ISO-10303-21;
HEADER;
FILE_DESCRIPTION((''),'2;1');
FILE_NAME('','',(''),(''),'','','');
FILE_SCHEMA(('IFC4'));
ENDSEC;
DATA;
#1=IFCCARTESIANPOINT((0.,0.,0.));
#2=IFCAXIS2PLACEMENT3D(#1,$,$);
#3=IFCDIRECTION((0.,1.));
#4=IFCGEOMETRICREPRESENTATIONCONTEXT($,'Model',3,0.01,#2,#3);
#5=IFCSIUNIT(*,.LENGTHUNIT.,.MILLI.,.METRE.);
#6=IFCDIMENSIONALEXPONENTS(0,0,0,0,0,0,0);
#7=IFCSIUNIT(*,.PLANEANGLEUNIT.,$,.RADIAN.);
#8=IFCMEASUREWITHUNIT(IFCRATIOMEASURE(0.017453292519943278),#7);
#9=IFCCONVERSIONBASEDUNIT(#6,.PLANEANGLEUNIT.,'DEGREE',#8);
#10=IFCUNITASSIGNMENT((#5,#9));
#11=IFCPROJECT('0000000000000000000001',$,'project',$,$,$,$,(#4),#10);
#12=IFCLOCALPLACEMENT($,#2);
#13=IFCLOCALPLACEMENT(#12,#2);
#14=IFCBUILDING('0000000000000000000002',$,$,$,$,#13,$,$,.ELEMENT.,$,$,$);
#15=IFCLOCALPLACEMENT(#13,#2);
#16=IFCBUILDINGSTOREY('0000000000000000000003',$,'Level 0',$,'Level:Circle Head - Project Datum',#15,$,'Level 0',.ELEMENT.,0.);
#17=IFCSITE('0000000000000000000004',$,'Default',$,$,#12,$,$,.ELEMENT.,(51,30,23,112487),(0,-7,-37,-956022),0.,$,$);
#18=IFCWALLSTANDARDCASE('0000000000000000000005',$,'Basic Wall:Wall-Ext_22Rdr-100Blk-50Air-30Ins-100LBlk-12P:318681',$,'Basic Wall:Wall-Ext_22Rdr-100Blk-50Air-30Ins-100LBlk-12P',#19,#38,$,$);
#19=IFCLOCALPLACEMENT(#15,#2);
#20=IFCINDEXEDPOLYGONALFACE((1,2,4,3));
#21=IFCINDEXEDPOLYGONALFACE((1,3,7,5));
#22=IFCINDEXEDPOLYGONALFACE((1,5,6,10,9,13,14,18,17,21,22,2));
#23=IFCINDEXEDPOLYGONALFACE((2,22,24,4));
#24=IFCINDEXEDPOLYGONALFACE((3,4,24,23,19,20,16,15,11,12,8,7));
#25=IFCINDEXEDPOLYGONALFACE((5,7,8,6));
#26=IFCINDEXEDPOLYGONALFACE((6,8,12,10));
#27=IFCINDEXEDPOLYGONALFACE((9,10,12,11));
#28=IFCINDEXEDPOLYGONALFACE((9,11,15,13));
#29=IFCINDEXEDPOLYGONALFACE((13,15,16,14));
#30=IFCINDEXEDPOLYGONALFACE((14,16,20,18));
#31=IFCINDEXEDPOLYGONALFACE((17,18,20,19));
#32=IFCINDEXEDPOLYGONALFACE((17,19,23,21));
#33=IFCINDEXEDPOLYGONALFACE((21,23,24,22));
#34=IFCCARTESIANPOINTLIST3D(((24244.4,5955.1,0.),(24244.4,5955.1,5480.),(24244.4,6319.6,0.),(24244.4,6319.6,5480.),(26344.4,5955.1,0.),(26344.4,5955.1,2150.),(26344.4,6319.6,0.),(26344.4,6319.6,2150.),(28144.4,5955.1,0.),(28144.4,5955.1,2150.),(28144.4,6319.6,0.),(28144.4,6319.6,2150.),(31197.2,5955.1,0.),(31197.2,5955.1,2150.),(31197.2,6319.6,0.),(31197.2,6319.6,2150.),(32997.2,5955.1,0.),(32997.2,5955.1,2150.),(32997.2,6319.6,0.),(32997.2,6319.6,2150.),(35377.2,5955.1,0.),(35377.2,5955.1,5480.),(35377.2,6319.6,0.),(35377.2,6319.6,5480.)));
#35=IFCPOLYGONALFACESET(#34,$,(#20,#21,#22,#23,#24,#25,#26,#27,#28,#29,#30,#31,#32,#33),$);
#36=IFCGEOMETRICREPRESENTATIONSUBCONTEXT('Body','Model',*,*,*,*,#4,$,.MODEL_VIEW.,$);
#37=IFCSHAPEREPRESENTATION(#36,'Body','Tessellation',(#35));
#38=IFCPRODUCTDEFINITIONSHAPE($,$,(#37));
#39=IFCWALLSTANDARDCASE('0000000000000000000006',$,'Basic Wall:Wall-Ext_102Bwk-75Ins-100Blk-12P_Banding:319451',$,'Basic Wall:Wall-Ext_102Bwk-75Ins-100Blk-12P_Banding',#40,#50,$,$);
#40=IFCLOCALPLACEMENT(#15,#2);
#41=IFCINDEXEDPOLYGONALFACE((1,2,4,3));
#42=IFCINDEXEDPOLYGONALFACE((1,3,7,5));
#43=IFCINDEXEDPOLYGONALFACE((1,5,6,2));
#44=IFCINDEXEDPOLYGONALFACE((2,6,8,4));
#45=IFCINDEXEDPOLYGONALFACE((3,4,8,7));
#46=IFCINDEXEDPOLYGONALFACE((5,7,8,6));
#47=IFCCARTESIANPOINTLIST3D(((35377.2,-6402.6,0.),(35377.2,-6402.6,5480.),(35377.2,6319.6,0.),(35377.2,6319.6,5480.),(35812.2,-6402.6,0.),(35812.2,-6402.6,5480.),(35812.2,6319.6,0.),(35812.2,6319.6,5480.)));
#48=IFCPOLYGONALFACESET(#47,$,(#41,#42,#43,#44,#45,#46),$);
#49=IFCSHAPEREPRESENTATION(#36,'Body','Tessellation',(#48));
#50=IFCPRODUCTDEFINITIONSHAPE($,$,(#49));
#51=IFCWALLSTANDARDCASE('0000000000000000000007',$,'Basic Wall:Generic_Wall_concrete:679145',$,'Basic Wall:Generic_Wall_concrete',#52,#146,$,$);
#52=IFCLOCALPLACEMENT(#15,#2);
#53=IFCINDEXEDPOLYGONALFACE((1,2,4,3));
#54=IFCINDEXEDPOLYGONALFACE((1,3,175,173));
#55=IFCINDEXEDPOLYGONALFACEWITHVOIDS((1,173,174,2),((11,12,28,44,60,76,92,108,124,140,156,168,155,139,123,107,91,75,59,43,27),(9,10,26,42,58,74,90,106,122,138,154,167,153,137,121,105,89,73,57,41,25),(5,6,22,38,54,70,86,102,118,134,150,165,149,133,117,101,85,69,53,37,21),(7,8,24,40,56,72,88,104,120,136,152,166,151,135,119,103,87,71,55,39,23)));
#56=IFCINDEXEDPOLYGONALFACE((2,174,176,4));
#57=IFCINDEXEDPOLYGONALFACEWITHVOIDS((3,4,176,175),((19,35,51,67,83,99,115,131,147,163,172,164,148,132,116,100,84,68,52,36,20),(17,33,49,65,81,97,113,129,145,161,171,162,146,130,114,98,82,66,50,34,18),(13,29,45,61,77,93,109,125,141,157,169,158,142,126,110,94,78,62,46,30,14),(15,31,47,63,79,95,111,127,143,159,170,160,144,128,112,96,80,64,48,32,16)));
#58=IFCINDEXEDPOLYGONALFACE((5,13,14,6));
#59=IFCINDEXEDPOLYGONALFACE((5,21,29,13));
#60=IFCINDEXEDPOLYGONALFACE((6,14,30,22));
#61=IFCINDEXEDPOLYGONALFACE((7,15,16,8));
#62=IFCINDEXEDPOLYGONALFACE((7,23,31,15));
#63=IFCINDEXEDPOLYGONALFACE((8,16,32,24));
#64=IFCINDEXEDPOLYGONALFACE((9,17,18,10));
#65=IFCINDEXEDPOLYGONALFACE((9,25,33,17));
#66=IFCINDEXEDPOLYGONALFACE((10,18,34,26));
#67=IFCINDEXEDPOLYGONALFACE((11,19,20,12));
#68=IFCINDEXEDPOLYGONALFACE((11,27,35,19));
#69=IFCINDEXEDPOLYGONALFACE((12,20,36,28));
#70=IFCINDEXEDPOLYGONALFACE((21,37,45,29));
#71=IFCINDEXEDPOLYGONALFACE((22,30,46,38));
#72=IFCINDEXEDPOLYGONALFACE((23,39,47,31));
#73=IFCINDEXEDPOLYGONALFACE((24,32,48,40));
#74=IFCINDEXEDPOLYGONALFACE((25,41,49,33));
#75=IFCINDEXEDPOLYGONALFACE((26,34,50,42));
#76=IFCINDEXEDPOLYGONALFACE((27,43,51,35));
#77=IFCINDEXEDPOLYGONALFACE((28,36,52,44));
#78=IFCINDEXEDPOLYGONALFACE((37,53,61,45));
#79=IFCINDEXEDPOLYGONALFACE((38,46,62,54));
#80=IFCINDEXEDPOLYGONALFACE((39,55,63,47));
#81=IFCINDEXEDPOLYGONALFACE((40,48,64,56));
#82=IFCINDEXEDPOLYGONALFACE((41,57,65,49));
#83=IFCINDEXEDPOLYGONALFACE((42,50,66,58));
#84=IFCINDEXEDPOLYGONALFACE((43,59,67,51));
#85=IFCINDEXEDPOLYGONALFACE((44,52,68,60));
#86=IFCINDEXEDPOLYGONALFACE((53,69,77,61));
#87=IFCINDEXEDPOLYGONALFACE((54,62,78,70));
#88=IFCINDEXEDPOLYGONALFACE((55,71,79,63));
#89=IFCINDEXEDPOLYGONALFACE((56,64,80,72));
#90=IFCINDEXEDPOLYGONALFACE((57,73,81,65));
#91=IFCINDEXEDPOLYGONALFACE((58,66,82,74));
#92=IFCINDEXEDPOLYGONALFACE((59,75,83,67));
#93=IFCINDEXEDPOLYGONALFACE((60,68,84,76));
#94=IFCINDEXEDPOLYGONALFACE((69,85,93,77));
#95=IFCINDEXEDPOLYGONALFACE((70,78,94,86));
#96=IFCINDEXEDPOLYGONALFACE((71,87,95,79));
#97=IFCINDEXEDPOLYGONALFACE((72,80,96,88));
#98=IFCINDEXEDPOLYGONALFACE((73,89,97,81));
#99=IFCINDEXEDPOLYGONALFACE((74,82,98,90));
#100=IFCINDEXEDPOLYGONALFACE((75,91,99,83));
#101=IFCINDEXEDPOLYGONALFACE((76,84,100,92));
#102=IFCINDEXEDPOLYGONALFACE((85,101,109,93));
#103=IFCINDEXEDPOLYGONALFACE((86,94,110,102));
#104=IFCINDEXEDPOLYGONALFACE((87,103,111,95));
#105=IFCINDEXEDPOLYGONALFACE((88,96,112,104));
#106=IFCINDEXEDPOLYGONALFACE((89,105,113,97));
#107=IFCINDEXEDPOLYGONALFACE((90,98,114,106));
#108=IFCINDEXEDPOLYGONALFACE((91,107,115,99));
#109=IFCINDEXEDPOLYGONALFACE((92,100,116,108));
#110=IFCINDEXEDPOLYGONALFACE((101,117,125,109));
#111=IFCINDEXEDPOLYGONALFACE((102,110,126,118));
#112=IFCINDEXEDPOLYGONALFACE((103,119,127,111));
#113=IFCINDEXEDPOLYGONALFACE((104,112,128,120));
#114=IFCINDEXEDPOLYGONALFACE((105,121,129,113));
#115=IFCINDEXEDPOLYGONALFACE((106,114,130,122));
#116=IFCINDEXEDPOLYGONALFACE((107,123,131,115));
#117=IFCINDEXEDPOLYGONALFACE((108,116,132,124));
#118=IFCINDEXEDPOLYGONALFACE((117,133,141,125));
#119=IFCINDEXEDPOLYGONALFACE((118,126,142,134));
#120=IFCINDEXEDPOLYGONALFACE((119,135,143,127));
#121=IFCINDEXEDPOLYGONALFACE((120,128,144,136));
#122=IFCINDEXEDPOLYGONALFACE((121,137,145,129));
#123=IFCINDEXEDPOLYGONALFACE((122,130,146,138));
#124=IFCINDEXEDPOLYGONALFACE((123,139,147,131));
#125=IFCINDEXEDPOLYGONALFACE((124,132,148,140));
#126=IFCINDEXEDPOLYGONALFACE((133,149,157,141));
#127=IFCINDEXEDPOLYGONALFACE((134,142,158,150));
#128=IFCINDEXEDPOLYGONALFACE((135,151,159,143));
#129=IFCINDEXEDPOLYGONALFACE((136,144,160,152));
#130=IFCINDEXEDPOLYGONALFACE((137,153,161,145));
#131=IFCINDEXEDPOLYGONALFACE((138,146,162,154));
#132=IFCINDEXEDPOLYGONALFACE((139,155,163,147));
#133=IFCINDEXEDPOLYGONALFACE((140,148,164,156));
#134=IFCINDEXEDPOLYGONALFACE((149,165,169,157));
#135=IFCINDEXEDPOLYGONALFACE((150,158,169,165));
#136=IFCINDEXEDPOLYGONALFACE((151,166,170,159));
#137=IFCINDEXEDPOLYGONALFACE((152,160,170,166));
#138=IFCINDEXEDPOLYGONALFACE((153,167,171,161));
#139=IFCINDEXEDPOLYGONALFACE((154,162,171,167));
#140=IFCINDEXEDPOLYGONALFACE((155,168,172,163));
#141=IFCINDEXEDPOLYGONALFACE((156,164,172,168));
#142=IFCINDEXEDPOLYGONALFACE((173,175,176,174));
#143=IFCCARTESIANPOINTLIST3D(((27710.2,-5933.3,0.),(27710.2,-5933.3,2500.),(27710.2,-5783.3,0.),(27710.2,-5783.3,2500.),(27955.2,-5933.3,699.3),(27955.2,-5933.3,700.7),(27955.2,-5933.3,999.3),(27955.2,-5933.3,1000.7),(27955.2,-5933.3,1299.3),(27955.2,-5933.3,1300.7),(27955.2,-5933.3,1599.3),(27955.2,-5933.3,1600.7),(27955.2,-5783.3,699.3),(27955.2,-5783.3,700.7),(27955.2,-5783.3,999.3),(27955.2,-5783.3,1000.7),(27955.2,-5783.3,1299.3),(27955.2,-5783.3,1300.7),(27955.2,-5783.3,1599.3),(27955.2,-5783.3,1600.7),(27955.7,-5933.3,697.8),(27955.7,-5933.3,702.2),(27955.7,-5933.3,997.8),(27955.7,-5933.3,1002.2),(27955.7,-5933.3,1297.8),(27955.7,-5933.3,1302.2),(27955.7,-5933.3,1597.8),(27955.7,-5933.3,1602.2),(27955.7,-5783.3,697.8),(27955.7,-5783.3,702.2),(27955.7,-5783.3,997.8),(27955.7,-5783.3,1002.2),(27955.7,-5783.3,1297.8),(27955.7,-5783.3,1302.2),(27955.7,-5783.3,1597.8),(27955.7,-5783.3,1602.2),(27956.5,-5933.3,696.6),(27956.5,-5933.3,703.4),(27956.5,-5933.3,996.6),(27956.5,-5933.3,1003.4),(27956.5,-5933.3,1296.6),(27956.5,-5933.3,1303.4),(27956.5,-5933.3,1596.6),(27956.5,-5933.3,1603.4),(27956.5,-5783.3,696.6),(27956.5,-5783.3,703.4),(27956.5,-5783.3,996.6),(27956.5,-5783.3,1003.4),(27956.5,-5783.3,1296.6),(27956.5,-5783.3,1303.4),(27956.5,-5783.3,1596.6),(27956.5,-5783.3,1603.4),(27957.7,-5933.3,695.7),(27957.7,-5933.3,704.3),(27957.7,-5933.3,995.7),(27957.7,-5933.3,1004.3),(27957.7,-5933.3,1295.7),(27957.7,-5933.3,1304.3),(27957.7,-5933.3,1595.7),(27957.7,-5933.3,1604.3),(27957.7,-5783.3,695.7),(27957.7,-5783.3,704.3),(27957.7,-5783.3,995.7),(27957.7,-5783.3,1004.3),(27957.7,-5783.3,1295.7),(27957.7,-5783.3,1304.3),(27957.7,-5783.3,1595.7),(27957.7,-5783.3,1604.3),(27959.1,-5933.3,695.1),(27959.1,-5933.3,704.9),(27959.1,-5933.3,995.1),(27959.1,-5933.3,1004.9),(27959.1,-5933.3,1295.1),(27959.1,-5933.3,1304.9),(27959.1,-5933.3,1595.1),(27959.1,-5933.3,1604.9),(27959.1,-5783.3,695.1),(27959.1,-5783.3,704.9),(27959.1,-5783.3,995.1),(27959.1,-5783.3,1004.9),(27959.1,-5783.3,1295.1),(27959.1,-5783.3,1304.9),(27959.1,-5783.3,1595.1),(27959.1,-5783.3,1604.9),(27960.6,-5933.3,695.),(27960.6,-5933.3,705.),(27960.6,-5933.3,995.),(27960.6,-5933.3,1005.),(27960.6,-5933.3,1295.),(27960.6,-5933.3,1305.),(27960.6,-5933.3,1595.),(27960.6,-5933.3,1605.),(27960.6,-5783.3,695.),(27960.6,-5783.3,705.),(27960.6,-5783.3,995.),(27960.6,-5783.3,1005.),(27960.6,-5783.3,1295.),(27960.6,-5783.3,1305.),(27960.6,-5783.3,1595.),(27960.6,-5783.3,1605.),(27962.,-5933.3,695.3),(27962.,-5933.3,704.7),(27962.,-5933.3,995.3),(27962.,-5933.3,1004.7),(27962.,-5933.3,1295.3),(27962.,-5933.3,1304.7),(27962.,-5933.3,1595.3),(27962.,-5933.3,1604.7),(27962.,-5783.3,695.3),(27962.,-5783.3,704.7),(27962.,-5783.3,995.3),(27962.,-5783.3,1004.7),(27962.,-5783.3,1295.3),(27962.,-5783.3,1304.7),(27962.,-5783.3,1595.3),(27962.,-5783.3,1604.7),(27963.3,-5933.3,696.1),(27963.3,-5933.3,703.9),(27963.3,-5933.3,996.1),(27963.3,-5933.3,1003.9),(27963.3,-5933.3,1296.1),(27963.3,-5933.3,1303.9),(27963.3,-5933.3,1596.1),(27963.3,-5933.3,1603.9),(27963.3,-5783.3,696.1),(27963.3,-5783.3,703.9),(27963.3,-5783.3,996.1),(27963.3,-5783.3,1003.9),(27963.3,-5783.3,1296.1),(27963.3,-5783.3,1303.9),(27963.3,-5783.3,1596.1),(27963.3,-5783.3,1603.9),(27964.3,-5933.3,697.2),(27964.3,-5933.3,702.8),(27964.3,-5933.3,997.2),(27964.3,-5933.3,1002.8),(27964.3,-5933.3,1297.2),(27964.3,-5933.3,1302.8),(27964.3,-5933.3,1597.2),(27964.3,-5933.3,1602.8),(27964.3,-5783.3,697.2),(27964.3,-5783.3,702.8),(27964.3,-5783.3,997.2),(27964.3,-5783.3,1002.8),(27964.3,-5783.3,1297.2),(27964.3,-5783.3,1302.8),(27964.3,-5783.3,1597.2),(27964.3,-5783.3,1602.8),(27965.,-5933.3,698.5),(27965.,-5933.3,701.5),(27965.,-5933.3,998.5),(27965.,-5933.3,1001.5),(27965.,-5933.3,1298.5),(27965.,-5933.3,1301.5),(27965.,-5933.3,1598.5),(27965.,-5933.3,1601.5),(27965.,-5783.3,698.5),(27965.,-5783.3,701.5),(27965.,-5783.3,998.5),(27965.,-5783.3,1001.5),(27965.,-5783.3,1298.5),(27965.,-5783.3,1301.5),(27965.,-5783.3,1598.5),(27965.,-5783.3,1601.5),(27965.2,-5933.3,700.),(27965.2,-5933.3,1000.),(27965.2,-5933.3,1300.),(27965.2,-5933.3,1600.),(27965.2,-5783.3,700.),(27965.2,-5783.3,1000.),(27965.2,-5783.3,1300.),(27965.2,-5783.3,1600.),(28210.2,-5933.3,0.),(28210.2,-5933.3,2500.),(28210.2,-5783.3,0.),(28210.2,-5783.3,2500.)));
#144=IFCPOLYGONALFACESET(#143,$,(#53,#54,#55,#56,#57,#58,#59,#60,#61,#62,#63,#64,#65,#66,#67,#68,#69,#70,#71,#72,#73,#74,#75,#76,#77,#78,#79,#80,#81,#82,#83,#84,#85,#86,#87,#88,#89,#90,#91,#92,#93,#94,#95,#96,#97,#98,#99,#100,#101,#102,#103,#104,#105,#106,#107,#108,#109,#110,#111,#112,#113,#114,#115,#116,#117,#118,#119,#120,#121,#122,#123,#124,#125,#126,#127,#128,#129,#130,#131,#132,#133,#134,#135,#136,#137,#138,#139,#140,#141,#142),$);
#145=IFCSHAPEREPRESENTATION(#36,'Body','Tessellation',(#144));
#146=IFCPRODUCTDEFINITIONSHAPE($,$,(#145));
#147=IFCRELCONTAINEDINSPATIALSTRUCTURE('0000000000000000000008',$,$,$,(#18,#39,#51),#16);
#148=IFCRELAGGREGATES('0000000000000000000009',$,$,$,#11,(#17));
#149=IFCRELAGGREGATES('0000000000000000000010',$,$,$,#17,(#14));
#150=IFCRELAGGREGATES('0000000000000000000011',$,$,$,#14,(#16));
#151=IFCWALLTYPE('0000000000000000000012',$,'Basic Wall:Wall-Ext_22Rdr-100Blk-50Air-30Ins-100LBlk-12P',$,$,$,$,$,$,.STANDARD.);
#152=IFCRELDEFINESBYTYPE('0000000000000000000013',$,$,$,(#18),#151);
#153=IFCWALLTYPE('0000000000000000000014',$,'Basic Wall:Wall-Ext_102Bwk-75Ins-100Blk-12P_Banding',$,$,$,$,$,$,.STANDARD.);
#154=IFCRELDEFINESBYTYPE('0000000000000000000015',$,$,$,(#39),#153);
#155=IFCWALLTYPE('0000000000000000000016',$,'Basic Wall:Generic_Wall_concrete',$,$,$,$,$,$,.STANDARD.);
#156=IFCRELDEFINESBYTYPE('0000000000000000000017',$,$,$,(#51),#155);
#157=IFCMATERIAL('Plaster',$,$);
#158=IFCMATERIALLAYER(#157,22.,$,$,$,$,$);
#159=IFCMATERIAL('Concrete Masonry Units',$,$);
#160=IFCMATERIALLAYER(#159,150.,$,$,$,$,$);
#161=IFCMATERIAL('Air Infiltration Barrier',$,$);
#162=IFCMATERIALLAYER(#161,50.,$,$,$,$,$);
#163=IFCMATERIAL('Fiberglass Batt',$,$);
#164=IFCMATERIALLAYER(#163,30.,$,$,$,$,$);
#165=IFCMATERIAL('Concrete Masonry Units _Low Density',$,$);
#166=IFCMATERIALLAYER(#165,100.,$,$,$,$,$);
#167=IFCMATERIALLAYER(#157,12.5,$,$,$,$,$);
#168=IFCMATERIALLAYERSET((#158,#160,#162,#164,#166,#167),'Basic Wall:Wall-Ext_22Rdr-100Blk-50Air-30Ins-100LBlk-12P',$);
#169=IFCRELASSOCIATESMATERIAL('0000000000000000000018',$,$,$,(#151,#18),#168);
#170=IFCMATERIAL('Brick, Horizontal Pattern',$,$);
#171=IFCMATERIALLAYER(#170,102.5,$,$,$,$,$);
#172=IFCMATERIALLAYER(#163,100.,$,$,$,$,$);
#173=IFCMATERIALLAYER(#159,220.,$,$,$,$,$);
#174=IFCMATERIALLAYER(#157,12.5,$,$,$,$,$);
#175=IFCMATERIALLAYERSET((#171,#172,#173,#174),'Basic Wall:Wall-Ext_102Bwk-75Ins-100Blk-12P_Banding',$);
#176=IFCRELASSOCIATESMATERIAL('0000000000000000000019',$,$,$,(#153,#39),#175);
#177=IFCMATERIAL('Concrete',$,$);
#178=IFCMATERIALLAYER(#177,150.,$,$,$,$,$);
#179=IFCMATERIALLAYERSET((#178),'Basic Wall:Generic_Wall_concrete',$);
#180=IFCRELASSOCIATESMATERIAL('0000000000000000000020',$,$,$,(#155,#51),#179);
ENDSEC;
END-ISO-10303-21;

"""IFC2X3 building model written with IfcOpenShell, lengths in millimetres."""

from ifc_helpers import new_model, entity, si_unit, converted_unit, direction, frame, frame_2d, origin, origin_2d_with_axis, place, context, subcontext, project, spatial, rectangle, circle, extrude, material, layer, layer_set, layer_usage, type_object, element, save


model = new_model("IFC2X3")

# Units and contexts
model_context = context("Model", 3, precision=0.01, world=origin(), true_north=direction((0.0, 1.0)))
body_context = subcontext(model_context, "Body", "Model", "MODEL_VIEW")
ifc_project = project(units=[si_unit("LENGTHUNIT", "METRE", prefix="MILLI"), converted_unit("PLANEANGLEUNIT", "DEGREE", entity("IfcRatioMeasure", 0.017453292519943278), si_unit("PLANEANGLEUNIT", "RADIAN"), dimensions=[0, 0, 0, 0, 0, 0, 0])], contexts=[model_context])

# Site, building, storey
site_placement = place(None, origin())
site = spatial("IfcSite", under=ifc_project, at=site_placement, Name="Default", CompositionType="ELEMENT", RefLatitude=(51, 30, 23, 112487), RefLongitude=(0, -7, -37, -956022), RefElevation=0.0)
building_placement = place(site_placement, origin())
building = spatial("IfcBuilding", under=site, at=building_placement, CompositionType="ELEMENT")
storey_placement = place(building_placement, origin())
storey = spatial("IfcBuildingStorey", under=building, at=storey_placement, Name="Level 0", ObjectType="Level:Circle Head - Project Datum", LongName="Level 0", CompositionType="ELEMENT", Elevation=0.0)

# Wall, openings
ifc_material_1 = material(Name="Plaster")
ifc_layer_1 = layer(ifc_material_1, 22.0)
ifc_material_2 = material(Name="Concrete Masonry Units")
ifc_layer_2 = layer(ifc_material_2, 150.0)
ifc_material_3 = material(Name="Air Infiltration Barrier")
ifc_layer_3 = layer(ifc_material_3, 50.0)
ifc_material_4 = material(Name="Fiberglass Batt")
ifc_layer_4 = layer(ifc_material_4, 30.0)
ifc_material_5 = material(Name="Concrete Masonry Units _Low Density")
ifc_layer_5 = layer(ifc_material_5, 100.0)
ifc_layer_6 = layer(ifc_material_1, 12.5)
ifc_layer_set_1 = layer_set([ifc_layer_1, ifc_layer_2, ifc_layer_3, ifc_layer_4, ifc_layer_5, ifc_layer_6], Name="Basic Wall:Wall-Ext_22Rdr-100Blk-50Air-30Ins-100LBlk-12P")
ifc_layer_usage_1 = layer_usage(ifc_layer_set_1, "AXIS2", "NEGATIVE", 182.3)
wall_type_1 = type_object("IfcWallType", Name="Basic Wall:Wall-Ext_22Rdr-100Blk-50Air-30Ins-100LBlk-12P", PredefinedType="STANDARD", material=ifc_layer_set_1)
wall_1_placement = place(storey_placement, frame((35377.2, 6137.4, 0.0), z_axis=(0.0, 0.0, 1.0), x_axis=(-1.0, 0.0, 0.0)))
wall_1 = element("IfcWallStandardCase", 1, at=wall_1_placement, inside=storey, type_object=wall_type_1, material=ifc_layer_usage_1, Name="Basic Wall:Wall-Ext_22Rdr-100Blk-50Air-30Ins-100LBlk-12P:318681", ObjectType="Basic Wall:Wall-Ext_22Rdr-100Blk-50Air-30Ins-100LBlk-12P", context=body_context, shape_type="SweptSolid", body=[
    extrude(rectangle(XDim=11132.8, YDim=364.5, at=frame_2d((5566.4, 0.0), x_axis=(1.0, 0.0))), origin(), (0.0, 0.0, 1.0), 5480.0),
])
opening_1_placement = place(wall_1_placement, frame((9032.7, 182.2, 0.0)))
element("IfcOpeningElement", 2, at=opening_1_placement, cuts=wall_1, ObjectType="Opening", context=body_context, shape_type="SweptSolid", body=[
    extrude(rectangle(XDim=2150.0, YDim=1800.0, at=frame_2d((1075.0, 900.0), x_axis=(1.0, 0.0))), frame((0.0, 0.0, 0.0), z_axis=(0.0, -1.0, 0.0), x_axis=(0.0, 0.0, 1.0)), (0.0, 0.0, 1.0), 364.5),
])
opening_2_placement = place(wall_1_placement, frame((4180.0, 182.2, 0.0)))
element("IfcOpeningElement", 3, at=opening_2_placement, cuts=wall_1, ObjectType="Opening", context=body_context, shape_type="SweptSolid", body=[
    extrude(rectangle(XDim=2150.0, YDim=1800.0, at=frame_2d((1075.0, 900.0), x_axis=(1.0, 0.0))), frame((0.0, 0.0, 0.0), z_axis=(0.0, -1.0, 0.0), x_axis=(0.0, 0.0, 1.0)), (0.0, 0.0, 1.0), 364.5),
])

# Wall
ifc_material_6 = material(Name="Brick, Horizontal Pattern")
ifc_layer_7 = layer(ifc_material_6, 102.5)
ifc_layer_8 = layer(ifc_material_4, 100.0)
ifc_layer_9 = layer(ifc_material_2, 220.0)
ifc_layer_10 = layer(ifc_material_1, 12.5)
ifc_layer_set_2 = layer_set([ifc_layer_7, ifc_layer_8, ifc_layer_9, ifc_layer_10], Name="Basic Wall:Wall-Ext_102Bwk-75Ins-100Blk-12P_Banding")
ifc_layer_usage_2 = layer_usage(ifc_layer_set_2, "AXIS2", "NEGATIVE", 217.5)
wall_type_2 = type_object("IfcWallType", Name="Basic Wall:Wall-Ext_102Bwk-75Ins-100Blk-12P_Banding", PredefinedType="STANDARD", material=ifc_layer_set_2)
wall_2_placement = place(storey_placement, frame((35594.7, 6319.6, 0.0), z_axis=(0.0, 0.0, 1.0), x_axis=(0.0, -1.0, 0.0)))
element("IfcWallStandardCase", 4, at=wall_2_placement, inside=storey, type_object=wall_type_2, material=ifc_layer_usage_2, Name="Basic Wall:Wall-Ext_102Bwk-75Ins-100Blk-12P_Banding:319451", ObjectType="Basic Wall:Wall-Ext_102Bwk-75Ins-100Blk-12P_Banding", context=body_context, shape_type="SweptSolid", body=[
    extrude(rectangle(XDim=12722.3, YDim=435.0, at=frame_2d((6361.1, 0.0), x_axis=(-1.0, 0.0))), origin(), (0.0, 0.0, 1.0), 5480.0),
])

# Wall, openings
ifc_material_7 = material(Name="Concrete")
ifc_layer_11 = layer(ifc_material_7, 150.0)
ifc_layer_set_3 = layer_set([ifc_layer_11], Name="Basic Wall:Generic_Wall_concrete")
ifc_layer_usage_3 = layer_usage(ifc_layer_set_3, "AXIS2", "NEGATIVE", 75.0)
wall_type_3 = type_object("IfcWallType", Name="Basic Wall:Generic_Wall_concrete", PredefinedType="STANDARD", material=ifc_layer_set_3)
wall_3_placement = place(storey_placement, frame((28210.2, -5858.3, 0.0), z_axis=(0.0, 0.0, 1.0), x_axis=(-1.0, 0.0, 0.0)))
wall_3 = element("IfcWallStandardCase", 5, at=wall_3_placement, inside=storey, type_object=wall_type_3, material=ifc_layer_usage_3, Name="Basic Wall:Generic_Wall_concrete:679145", ObjectType="Basic Wall:Generic_Wall_concrete", context=body_context, shape_type="SweptSolid", body=[
    extrude(rectangle(XDim=500.0, YDim=150.0, at=frame_2d((250.0, 0.0), x_axis=(-1.0, 0.0))), origin(), (0.0, 0.0, 1.0), 2500.0),
])
opening_3_placement = place(wall_3_placement, origin())
element("IfcOpeningElement", 6, at=opening_3_placement, cuts=wall_3, ObjectType="Opening", context=body_context, shape_type="SweptSolid", body=[
    extrude(circle(Radius=5.0, at=origin_2d_with_axis()), frame((250.0, -75.0, 700.0), z_axis=(0.0, 1.0, 0.0), x_axis=(-1.0, 0.0, 0.0)), (0.0, 0.0, 1.0), 200.0),
])
opening_4_placement = place(wall_3_placement, origin())
element("IfcOpeningElement", 7, at=opening_4_placement, cuts=wall_3, ObjectType="Opening", context=body_context, shape_type="SweptSolid", body=[
    extrude(circle(Radius=5.0, at=origin_2d_with_axis()), frame((250.0, -75.0, 1000.0), z_axis=(0.0, 1.0, 0.0), x_axis=(-1.0, 0.0, 0.0)), (0.0, 0.0, 1.0), 200.0),
])
opening_5_placement = place(wall_3_placement, origin())
element("IfcOpeningElement", 8, at=opening_5_placement, cuts=wall_3, ObjectType="Opening", context=body_context, shape_type="SweptSolid", body=[
    extrude(circle(Radius=5.0, at=origin_2d_with_axis()), frame((250.0, -75.0, 1300.0), z_axis=(0.0, 1.0, 0.0), x_axis=(-1.0, 0.0, 0.0)), (0.0, 0.0, 1.0), 200.0),
])
opening_6_placement = place(wall_3_placement, origin())
element("IfcOpeningElement", 9, at=opening_6_placement, cuts=wall_3, ObjectType="Opening", context=body_context, shape_type="SweptSolid", body=[
    extrude(circle(Radius=5.0, at=origin_2d_with_axis()), frame((250.0, -75.0, 1600.0), z_axis=(0.0, 1.0, 0.0), x_axis=(-1.0, 0.0, 0.0)), (0.0, 0.0, 1.0), 200.0),
])

save(model, "model.ifc")
